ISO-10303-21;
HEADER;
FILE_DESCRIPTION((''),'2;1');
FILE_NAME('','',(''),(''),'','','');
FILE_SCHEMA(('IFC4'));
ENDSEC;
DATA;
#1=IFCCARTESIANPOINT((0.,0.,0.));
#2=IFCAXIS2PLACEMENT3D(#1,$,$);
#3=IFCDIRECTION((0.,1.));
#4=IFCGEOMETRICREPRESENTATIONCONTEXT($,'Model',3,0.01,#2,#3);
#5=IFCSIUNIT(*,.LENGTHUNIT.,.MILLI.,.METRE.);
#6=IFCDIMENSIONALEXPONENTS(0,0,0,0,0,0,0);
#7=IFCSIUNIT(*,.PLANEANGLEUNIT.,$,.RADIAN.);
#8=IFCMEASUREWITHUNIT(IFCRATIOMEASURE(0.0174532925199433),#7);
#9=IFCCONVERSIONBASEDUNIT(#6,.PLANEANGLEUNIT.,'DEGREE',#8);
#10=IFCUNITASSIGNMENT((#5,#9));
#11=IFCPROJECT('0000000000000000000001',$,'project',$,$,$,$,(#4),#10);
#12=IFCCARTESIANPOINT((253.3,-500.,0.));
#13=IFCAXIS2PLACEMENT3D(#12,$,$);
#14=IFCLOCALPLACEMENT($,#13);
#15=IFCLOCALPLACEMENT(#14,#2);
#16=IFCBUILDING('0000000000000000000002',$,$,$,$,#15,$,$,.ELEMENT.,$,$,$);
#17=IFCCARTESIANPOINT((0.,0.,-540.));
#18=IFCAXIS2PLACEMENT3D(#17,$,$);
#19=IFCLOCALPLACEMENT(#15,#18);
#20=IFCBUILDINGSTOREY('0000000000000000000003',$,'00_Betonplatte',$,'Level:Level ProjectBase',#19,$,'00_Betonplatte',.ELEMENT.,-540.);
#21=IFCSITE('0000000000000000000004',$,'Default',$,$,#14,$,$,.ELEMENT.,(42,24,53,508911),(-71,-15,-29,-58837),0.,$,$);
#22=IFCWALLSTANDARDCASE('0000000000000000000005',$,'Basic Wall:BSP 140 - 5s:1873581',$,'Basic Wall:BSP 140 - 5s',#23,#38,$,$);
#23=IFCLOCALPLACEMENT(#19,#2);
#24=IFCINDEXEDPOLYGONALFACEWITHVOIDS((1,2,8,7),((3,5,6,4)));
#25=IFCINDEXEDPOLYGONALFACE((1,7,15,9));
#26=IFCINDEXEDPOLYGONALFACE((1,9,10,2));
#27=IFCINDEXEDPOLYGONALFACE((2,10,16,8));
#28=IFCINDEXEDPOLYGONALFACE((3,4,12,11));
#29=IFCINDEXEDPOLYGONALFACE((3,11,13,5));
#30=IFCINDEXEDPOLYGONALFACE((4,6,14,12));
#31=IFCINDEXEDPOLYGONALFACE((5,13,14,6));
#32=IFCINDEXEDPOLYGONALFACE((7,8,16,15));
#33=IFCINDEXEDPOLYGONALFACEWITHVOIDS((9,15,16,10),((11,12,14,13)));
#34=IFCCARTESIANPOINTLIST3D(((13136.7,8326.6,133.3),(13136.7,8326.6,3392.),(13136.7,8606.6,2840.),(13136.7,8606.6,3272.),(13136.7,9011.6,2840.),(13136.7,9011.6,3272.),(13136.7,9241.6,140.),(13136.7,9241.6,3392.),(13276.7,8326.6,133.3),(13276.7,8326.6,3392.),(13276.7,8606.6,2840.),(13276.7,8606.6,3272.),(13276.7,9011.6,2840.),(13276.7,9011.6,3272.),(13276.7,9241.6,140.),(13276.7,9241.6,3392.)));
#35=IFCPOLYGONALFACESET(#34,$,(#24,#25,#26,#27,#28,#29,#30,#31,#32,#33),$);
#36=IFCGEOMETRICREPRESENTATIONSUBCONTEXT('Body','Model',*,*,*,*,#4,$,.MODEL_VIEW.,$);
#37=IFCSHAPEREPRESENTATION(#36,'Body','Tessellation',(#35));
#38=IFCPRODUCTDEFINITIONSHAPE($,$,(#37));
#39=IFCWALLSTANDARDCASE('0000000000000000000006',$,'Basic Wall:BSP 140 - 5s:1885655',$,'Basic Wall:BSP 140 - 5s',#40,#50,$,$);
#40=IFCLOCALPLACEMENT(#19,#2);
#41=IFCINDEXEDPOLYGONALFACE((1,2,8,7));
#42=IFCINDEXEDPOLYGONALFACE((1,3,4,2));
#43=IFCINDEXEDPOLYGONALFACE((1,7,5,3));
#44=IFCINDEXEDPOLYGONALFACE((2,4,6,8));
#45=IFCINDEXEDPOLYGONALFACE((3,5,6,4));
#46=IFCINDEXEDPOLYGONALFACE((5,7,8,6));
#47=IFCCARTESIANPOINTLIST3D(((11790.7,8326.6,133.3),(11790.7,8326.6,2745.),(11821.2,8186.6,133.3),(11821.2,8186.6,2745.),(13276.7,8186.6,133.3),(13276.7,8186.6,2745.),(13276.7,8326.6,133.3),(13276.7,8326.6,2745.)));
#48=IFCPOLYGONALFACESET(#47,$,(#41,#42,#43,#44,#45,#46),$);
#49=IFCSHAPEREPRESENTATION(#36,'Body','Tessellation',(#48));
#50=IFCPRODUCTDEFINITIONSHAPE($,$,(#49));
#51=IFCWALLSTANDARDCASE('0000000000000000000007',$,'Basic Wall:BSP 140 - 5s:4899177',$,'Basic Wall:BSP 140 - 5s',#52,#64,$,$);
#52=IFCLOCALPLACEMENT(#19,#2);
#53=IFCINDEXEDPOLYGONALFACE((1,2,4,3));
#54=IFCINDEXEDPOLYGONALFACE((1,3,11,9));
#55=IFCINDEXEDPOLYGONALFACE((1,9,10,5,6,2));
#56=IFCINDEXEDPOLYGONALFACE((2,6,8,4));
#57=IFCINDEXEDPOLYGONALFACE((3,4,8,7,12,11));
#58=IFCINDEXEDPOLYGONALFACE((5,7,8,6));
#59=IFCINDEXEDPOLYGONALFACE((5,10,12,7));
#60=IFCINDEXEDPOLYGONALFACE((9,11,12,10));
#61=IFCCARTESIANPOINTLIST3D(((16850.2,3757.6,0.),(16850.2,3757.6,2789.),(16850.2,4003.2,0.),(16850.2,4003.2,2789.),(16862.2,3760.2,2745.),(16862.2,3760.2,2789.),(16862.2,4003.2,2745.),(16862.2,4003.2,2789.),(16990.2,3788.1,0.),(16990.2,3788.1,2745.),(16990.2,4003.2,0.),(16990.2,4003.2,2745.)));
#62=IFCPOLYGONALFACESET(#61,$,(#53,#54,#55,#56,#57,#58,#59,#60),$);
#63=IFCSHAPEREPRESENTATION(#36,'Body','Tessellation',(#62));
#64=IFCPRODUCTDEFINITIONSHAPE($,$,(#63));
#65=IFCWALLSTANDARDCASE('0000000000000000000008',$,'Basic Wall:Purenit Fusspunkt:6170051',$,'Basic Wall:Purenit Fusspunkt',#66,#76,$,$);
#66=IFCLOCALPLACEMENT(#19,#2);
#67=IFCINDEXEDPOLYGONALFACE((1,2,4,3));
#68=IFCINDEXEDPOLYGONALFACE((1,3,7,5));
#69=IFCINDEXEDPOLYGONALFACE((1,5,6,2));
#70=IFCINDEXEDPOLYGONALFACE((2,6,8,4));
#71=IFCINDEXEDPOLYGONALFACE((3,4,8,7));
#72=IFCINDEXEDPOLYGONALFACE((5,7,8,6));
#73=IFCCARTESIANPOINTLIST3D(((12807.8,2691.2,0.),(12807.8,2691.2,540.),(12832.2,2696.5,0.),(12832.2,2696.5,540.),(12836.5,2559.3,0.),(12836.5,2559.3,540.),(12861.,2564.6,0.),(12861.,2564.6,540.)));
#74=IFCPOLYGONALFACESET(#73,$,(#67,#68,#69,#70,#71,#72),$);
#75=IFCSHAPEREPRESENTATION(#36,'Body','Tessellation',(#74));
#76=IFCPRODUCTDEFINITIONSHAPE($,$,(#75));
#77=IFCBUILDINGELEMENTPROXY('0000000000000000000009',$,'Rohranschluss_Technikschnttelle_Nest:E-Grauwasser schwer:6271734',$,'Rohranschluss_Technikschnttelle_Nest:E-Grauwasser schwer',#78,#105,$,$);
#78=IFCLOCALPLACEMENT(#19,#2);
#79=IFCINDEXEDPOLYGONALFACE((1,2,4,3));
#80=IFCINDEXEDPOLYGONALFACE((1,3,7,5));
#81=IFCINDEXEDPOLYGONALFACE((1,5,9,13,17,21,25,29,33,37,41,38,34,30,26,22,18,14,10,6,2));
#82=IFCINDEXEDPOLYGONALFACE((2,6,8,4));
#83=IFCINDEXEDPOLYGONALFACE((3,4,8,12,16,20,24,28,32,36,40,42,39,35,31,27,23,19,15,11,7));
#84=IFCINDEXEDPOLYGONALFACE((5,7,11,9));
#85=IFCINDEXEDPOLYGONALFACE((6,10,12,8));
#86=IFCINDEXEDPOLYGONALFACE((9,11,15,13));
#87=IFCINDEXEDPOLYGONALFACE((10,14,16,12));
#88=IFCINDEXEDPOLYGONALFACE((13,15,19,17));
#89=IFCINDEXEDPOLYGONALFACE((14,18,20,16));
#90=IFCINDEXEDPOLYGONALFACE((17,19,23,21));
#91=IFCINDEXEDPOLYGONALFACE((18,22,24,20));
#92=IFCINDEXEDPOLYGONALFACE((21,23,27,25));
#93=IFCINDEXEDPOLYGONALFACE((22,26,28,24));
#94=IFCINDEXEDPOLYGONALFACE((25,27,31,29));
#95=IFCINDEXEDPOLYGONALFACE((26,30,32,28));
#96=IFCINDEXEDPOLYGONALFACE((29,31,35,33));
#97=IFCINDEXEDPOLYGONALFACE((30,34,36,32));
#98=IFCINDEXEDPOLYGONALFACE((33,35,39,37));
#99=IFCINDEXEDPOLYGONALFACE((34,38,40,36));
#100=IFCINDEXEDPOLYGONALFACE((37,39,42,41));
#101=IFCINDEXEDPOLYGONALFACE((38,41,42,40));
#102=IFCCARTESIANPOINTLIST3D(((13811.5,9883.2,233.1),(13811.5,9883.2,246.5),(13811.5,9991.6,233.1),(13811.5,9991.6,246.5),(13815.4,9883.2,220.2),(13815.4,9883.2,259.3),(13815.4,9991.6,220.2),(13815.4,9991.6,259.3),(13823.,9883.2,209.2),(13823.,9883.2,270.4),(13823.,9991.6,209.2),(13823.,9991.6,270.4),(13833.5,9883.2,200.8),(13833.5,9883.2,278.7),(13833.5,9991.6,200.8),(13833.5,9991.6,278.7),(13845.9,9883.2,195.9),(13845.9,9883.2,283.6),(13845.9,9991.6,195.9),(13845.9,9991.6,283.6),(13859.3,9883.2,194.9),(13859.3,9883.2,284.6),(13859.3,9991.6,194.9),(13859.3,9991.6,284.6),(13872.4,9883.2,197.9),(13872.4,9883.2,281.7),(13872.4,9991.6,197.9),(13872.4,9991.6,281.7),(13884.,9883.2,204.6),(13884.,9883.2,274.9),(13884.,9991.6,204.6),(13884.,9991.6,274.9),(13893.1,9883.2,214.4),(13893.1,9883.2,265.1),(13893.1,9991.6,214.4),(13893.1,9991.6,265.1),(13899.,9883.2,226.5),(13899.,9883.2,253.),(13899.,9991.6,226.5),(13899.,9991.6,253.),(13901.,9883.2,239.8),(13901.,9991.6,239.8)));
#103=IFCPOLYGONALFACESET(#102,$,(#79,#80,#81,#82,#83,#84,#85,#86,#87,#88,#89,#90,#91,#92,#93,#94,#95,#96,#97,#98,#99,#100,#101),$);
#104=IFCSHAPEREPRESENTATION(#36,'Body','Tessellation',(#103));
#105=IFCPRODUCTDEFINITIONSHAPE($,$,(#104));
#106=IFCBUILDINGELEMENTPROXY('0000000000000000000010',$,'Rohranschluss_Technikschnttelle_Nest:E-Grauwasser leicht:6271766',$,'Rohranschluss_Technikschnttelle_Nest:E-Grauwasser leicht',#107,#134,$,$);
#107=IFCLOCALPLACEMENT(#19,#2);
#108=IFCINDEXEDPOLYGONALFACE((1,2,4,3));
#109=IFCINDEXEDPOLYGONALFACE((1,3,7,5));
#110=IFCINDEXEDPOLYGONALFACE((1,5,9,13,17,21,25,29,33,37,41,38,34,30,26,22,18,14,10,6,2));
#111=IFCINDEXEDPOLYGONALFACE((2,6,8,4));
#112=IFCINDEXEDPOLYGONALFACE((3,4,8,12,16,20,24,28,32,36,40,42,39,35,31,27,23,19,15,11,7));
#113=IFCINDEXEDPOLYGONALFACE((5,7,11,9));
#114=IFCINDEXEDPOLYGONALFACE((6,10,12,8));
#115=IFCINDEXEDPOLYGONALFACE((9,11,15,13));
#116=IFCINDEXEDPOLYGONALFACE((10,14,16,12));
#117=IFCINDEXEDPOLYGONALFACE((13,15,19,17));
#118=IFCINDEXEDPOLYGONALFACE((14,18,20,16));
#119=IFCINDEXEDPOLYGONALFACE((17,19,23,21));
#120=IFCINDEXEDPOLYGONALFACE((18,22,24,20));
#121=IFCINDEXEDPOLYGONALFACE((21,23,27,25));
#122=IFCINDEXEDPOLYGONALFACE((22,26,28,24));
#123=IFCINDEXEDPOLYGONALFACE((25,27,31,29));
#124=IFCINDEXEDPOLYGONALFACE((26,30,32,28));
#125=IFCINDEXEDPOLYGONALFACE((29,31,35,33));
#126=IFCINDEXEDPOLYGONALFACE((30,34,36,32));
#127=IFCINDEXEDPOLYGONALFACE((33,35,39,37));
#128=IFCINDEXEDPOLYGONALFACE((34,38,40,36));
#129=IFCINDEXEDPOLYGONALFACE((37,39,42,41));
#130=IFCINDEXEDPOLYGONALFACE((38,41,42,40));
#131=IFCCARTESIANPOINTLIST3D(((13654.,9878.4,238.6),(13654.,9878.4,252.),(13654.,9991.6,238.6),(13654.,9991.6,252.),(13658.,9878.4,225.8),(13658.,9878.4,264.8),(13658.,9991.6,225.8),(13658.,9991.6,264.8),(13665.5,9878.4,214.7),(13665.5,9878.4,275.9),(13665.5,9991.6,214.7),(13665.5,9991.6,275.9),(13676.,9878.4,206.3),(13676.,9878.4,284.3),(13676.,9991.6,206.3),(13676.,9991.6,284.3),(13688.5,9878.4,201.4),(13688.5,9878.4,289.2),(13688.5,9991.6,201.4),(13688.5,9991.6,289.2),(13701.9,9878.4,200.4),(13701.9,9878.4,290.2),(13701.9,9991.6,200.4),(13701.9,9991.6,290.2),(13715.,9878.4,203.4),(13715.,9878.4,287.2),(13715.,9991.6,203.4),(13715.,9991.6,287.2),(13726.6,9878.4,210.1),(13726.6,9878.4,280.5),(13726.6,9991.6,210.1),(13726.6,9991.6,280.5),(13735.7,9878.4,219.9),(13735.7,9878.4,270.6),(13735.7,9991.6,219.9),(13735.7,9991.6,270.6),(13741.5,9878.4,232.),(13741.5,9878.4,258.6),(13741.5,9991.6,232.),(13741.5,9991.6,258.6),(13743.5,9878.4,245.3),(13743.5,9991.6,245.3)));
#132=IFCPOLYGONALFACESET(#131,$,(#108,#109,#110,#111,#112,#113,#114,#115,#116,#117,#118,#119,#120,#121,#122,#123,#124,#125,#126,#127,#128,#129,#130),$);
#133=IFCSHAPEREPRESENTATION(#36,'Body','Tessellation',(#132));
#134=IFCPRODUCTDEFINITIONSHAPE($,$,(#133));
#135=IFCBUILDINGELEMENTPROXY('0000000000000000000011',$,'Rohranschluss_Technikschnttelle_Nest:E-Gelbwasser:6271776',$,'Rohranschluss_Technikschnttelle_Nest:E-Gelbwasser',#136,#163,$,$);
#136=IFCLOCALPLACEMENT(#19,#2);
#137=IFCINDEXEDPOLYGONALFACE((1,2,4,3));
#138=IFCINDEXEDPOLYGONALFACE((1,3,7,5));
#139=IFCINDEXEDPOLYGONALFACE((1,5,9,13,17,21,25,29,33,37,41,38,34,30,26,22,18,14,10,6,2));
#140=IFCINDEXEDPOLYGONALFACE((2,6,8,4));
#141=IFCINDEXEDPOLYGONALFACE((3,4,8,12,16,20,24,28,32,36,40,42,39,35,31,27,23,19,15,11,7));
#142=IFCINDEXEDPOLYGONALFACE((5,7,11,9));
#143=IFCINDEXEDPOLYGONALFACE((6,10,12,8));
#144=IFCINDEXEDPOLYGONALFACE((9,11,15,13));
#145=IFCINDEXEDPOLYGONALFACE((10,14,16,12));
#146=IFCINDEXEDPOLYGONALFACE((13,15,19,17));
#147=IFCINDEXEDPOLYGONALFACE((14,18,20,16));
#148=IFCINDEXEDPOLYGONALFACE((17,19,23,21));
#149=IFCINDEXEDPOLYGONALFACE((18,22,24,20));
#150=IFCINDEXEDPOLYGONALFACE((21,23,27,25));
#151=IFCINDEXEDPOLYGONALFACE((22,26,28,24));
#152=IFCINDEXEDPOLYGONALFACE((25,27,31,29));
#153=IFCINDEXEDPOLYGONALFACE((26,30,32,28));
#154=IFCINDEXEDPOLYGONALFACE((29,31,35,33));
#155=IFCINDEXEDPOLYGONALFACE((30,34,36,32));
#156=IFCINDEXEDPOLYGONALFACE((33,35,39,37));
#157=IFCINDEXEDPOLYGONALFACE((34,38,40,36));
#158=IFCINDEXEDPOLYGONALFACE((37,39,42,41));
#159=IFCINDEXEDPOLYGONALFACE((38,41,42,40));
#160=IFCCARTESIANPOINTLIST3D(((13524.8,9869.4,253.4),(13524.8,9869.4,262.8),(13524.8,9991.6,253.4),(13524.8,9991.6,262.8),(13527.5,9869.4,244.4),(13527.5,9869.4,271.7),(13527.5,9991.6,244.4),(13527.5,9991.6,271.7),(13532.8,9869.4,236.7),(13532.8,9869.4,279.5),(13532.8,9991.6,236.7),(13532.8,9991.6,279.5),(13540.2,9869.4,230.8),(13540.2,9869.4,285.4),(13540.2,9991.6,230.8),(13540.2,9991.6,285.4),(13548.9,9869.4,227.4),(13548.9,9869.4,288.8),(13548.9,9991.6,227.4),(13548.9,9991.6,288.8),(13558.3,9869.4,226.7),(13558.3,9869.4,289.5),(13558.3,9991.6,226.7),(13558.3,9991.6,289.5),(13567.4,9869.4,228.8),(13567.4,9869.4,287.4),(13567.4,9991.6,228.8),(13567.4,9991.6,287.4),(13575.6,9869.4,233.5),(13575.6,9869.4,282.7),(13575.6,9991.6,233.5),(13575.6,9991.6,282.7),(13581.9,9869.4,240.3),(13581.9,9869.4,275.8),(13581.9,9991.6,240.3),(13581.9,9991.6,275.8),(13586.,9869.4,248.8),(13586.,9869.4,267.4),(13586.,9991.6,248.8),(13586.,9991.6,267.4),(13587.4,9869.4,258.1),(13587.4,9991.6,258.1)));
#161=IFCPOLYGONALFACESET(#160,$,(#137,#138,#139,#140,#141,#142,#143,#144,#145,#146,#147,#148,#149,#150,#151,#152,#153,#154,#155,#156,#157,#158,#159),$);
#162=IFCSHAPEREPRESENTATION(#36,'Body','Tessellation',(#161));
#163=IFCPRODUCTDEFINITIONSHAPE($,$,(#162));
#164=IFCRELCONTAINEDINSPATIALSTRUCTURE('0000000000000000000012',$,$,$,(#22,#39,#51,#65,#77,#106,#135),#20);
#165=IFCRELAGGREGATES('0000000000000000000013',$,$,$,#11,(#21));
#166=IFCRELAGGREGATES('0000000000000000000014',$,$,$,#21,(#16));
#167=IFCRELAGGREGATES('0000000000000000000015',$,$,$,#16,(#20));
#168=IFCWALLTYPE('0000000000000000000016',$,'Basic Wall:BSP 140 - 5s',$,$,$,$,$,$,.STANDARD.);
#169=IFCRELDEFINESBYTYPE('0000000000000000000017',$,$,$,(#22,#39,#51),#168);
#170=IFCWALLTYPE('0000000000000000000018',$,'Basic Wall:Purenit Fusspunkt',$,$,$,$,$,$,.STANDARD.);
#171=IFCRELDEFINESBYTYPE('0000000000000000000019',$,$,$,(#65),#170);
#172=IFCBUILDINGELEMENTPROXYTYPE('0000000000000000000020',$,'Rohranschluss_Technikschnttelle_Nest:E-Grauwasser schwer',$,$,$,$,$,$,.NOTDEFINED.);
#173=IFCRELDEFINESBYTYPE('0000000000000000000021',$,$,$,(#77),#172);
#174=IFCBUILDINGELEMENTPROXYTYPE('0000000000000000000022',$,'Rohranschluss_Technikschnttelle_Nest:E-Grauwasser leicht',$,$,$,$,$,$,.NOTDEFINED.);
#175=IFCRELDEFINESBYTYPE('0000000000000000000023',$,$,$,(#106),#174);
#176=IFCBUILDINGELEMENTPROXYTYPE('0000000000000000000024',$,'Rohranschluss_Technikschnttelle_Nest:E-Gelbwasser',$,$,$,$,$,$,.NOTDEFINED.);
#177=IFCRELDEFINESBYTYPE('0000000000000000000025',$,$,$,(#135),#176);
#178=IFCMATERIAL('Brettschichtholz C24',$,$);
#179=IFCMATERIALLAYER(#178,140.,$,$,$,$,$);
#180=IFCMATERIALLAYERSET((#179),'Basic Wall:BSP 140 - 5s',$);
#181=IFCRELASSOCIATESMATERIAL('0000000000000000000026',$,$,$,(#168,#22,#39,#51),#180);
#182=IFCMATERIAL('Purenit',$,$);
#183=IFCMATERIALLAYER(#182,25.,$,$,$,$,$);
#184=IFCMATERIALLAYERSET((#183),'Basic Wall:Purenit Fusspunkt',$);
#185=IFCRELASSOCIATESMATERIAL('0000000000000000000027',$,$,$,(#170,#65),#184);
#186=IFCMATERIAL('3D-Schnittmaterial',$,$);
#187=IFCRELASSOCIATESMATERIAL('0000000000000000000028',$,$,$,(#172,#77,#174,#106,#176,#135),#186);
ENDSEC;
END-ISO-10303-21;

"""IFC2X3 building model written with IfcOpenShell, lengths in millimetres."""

from ifc_helpers import new_model, entity, si_unit, converted_unit, direction, frame, frame_2d, origin, place, context, subcontext, project, spatial, polyline, rectangle, circle, outline, extrude, clip, halfspace, bounded_halfspace, source, transform, mapped, material, layer, layer_set, layer_usage, type_object, type_shapes, element, save


model = new_model("IFC2X3")

# Units and contexts
model_context = context("Model", 3, precision=0.01, world=origin(), true_north=direction((0.0, 1.0)))
body_context = subcontext(model_context, "Body", "Model", "MODEL_VIEW")
ifc_project = project(units=[si_unit("LENGTHUNIT", "METRE", prefix="MILLI"), converted_unit("PLANEANGLEUNIT", "DEGREE", entity("IfcRatioMeasure", 0.0174532925199433), si_unit("PLANEANGLEUNIT", "RADIAN"), dimensions=[0, 0, 0, 0, 0, 0, 0])], contexts=[model_context])

# Site, building, storey
site_placement = place(None, frame((253.3, -500.0, 0.0)))
site = spatial("IfcSite", under=ifc_project, at=site_placement, Name="Default", CompositionType="ELEMENT", RefLatitude=(42, 24, 53, 508911), RefLongitude=(-71, -15, -29, -58837), RefElevation=0.0)
building_placement = place(site_placement, origin())
building = spatial("IfcBuilding", under=site, at=building_placement, CompositionType="ELEMENT")
storey_placement = place(building_placement, frame((0.0, 0.0, -540.0)))
storey = spatial("IfcBuildingStorey", under=building, at=storey_placement, Name="00_Betonplatte", ObjectType="Level:Level ProjectBase", LongName="00_Betonplatte", CompositionType="ELEMENT", Elevation=-540.0)

# Wall, opening
ifc_material_1 = material(Name="Brettschichtholz C24")
ifc_layer_1 = layer(ifc_material_1, 140.0)
ifc_layer_set_1 = layer_set([ifc_layer_1], Name="Basic Wall:BSP 140 - 5s")
ifc_layer_usage_1 = layer_usage(ifc_layer_set_1, "AXIS2", "POSITIVE", -70.0)
wall_type_1 = type_object("IfcWallType", Name="Basic Wall:BSP 140 - 5s", PredefinedType="STANDARD", material=ifc_layer_set_1)
wall_1_placement = place(storey_placement, frame((13206.7, 9241.6, 133.3), z_axis=(0.0, 0.0, 1.0), x_axis=(0.0, -1.0, 0.0)))
wall_1 = element("IfcWallStandardCase", 1, at=wall_1_placement, inside=storey, type_object=wall_type_1, material=ifc_layer_usage_1, Name="Basic Wall:BSP 140 - 5s:1873581", ObjectType="Basic Wall:BSP 140 - 5s", context=body_context, shape_type="Clipping", body=[
    clip(extrude(rectangle(XDim=915.0, YDim=140.0, at=frame_2d((457.5, 0.0), x_axis=(-1.0, 0.0))), origin(), (0.0, 0.0, 1.0), 3258.7), halfspace(frame((915.0, -70.0, 0.0), z_axis=(-0.007349, 0.0, -0.999973), x_axis=(0.0, 1.0, 0.0)), False)),
])
opening_1_placement = place(wall_1_placement, frame((635.0, -2569.0, 2706.7)))
element("IfcOpeningElement", 2, at=opening_1_placement, cuts=wall_1, ObjectType="Opening", context=body_context, shape_type="SweptSolid", body=[
    extrude(rectangle(XDim=432.0, YDim=405.0, at=frame_2d((0.0, 0.0), x_axis=(0.0, 1.0))), frame((-202.5, 0.0, 216.0), z_axis=(0.0, 1.0, 0.0), x_axis=(1.0, 0.0, 0.0)), (0.0, 0.0, 1.0), 2639.0),
])

# Walls
ifc_layer_usage_2 = layer_usage(ifc_layer_set_1, "AXIS2", "NEGATIVE", 70.0)
wall_2_placement = place(storey_placement, frame((11790.7, 8256.6, 133.3)))
element("IfcWallStandardCase", 3, at=wall_2_placement, inside=storey, type_object=wall_type_1, material=ifc_layer_usage_2, Name="Basic Wall:BSP 140 - 5s:1885655", ObjectType="Basic Wall:BSP 140 - 5s", context=body_context, shape_type="SweptSolid", body=[
    extrude(outline(polyline([(1486.0, -70.0), (1486.0, 70.0), (0.0, 70.0), (30.6, -70.0), (1486.0, -70.0)])), origin(), (0.0, 0.0, 1.0), 2611.7),
])
ifc_layer_usage_3 = layer_usage(ifc_layer_set_1, "AXIS2", "NEGATIVE", 70.0)
wall_3_placement = place(storey_placement, frame((16920.2, 3757.6, 0.0), z_axis=(0.0, 0.0, 1.0), x_axis=(0.0, 1.0, 0.0)))
element("IfcWallStandardCase", 4, at=wall_3_placement, inside=storey, type_object=wall_type_1, material=ifc_layer_usage_3, Name="Basic Wall:BSP 140 - 5s:4899177", ObjectType="Basic Wall:BSP 140 - 5s", context=body_context, shape_type="Clipping", body=[
    clip(clip(extrude(outline(polyline([(245.6, -70.0), (245.6, 70.0), (0.0, 70.0), (30.6, -70.0), (245.6, -70.0)])), origin(), (0.0, 0.0, 1.0), 2789.0), bounded_halfspace(frame((30.6, -70.0, 2745.0), z_axis=(0.0, 0.0, -1.0), x_axis=(-1.0, 0.0, 0.0)), True, frame((30.6, -70.0, 2745.0), z_axis=(0.0, 0.0, -1.0), x_axis=(-1.0, 0.0, 0.0)), polyline([(0.0, 0.0), (26.3, 120.5), (27.9, 128.0), (-215.1, 128.0), (-215.1, 0.0), (0.0, 0.0)]))), bounded_halfspace(frame((245.6, 58.0, 2789.0), z_axis=(0.0, 1.0, 0.0), x_axis=(-1.0, 0.0, 0.0)), True, frame((245.6, 58.0, 2789.0), z_axis=(0.0, 1.0, 0.0), x_axis=(-1.0, 0.0, 0.0)), polyline([(0.0, 0.0), (0.0, -44.0), (243.0, -44.0), (243.0, 0.0), (0.0, 0.0)]))),
])
ifc_material_2 = material(Name="Purenit")
ifc_layer_2 = layer(ifc_material_2, 25.0)
ifc_layer_set_2 = layer_set([ifc_layer_2], Name="Basic Wall:Purenit Fusspunkt")
ifc_layer_usage_4 = layer_usage(ifc_layer_set_2, "AXIS2", "POSITIVE", -12.5)
wall_type_2 = type_object("IfcWallType", Name="Basic Wall:Purenit Fusspunkt", PredefinedType="STANDARD", material=ifc_layer_set_2)
wall_4_placement = place(storey_placement, frame((12848.8, 2562.0, 0.0), z_axis=(0.0, 0.0, 1.0), x_axis=(-0.213201, 0.977008, 0.0)))
element("IfcWallStandardCase", 5, at=wall_4_placement, inside=storey, type_object=wall_type_2, material=ifc_layer_usage_4, Name="Basic Wall:Purenit Fusspunkt:6170051", ObjectType="Basic Wall:Purenit Fusspunkt", context=body_context, shape_type="SweptSolid", body=[
    extrude(rectangle(XDim=135.0, YDim=25.0, at=frame_2d((67.5, 0.0), x_axis=(-1.0, 0.0))), origin(), (0.0, 0.0, 1.0), 540.0),
])

# Building element proxies
ifc_material_3 = material(Name="3D-Schnittmaterial")
building_element_proxy_type_1 = type_object("IfcBuildingElementProxyType", Name="Rohranschluss_Technikschnttelle_Nest:E-Grauwasser schwer", PredefinedType="NOTDEFINED", material=ifc_material_3)
shared_shape_1 = source(origin(), body_context, "Body", "SweptSolid", [
    extrude(circle(Radius=45.0, at=frame_2d((0.0, 0.0), x_axis=(1.0, 0.0))), frame((0.0, -108.5, 0.0), z_axis=(0.0, 1.0, 0.0), x_axis=(1.0, 0.0, 0.0)), (0.0, 0.0, 1.0), 108.5),
])
type_shapes(building_element_proxy_type_1, [shared_shape_1])
proxy_1_placement = place(storey_placement, frame((13856.0, 9991.6, 239.8)))
element("IfcBuildingElementProxy", 6, at=proxy_1_placement, inside=storey, type_object=building_element_proxy_type_1, material=ifc_material_3, Name="Rohranschluss_Technikschnttelle_Nest:E-Grauwasser schwer:6271734", ObjectType="Rohranschluss_Technikschnttelle_Nest:E-Grauwasser schwer", context=body_context, shape_type="MappedRepresentation", body=[
    mapped(shared_shape_1, transform((0.0, 0.0, 0.0), scale=1.0)),
])
building_element_proxy_type_2 = type_object("IfcBuildingElementProxyType", Name="Rohranschluss_Technikschnttelle_Nest:E-Grauwasser leicht", PredefinedType="NOTDEFINED", material=ifc_material_3)
shared_shape_2 = source(origin(), body_context, "Body", "SweptSolid", [
    extrude(circle(Radius=45.0, at=frame_2d((0.0, 0.0), x_axis=(1.0, 0.0))), frame((0.0, -113.2, 0.0), z_axis=(0.0, 1.0, 0.0), x_axis=(1.0, 0.0, 0.0)), (0.0, 0.0, 1.0), 113.2),
])
type_shapes(building_element_proxy_type_2, [shared_shape_2])
proxy_2_placement = place(storey_placement, frame((13698.5, 9991.6, 245.3)))
element("IfcBuildingElementProxy", 7, at=proxy_2_placement, inside=storey, type_object=building_element_proxy_type_2, material=ifc_material_3, Name="Rohranschluss_Technikschnttelle_Nest:E-Grauwasser leicht:6271766", ObjectType="Rohranschluss_Technikschnttelle_Nest:E-Grauwasser leicht", context=body_context, shape_type="MappedRepresentation", body=[
    mapped(shared_shape_2, transform((0.0, 0.0, 0.0), scale=1.0)),
])
building_element_proxy_type_3 = type_object("IfcBuildingElementProxyType", Name="Rohranschluss_Technikschnttelle_Nest:E-Gelbwasser", PredefinedType="NOTDEFINED", material=ifc_material_3)
shared_shape_3 = source(origin(), body_context, "Body", "SweptSolid", [
    extrude(circle(Radius=31.5, at=frame_2d((0.0, 0.0), x_axis=(1.0, 0.0))), frame((0.0, -122.3, 0.0), z_axis=(0.0, 1.0, 0.0), x_axis=(1.0, 0.0, 0.0)), (0.0, 0.0, 1.0), 122.3),
])
type_shapes(building_element_proxy_type_3, [shared_shape_3])
proxy_3_placement = place(storey_placement, frame((13555.9, 9991.6, 258.1)))
element("IfcBuildingElementProxy", 8, at=proxy_3_placement, inside=storey, type_object=building_element_proxy_type_3, material=ifc_material_3, Name="Rohranschluss_Technikschnttelle_Nest:E-Gelbwasser:6271776", ObjectType="Rohranschluss_Technikschnttelle_Nest:E-Gelbwasser", context=body_context, shape_type="MappedRepresentation", body=[
    mapped(shared_shape_3, transform((0.0, 0.0, 0.0), scale=1.0)),
])

save(model, "model.ifc")
